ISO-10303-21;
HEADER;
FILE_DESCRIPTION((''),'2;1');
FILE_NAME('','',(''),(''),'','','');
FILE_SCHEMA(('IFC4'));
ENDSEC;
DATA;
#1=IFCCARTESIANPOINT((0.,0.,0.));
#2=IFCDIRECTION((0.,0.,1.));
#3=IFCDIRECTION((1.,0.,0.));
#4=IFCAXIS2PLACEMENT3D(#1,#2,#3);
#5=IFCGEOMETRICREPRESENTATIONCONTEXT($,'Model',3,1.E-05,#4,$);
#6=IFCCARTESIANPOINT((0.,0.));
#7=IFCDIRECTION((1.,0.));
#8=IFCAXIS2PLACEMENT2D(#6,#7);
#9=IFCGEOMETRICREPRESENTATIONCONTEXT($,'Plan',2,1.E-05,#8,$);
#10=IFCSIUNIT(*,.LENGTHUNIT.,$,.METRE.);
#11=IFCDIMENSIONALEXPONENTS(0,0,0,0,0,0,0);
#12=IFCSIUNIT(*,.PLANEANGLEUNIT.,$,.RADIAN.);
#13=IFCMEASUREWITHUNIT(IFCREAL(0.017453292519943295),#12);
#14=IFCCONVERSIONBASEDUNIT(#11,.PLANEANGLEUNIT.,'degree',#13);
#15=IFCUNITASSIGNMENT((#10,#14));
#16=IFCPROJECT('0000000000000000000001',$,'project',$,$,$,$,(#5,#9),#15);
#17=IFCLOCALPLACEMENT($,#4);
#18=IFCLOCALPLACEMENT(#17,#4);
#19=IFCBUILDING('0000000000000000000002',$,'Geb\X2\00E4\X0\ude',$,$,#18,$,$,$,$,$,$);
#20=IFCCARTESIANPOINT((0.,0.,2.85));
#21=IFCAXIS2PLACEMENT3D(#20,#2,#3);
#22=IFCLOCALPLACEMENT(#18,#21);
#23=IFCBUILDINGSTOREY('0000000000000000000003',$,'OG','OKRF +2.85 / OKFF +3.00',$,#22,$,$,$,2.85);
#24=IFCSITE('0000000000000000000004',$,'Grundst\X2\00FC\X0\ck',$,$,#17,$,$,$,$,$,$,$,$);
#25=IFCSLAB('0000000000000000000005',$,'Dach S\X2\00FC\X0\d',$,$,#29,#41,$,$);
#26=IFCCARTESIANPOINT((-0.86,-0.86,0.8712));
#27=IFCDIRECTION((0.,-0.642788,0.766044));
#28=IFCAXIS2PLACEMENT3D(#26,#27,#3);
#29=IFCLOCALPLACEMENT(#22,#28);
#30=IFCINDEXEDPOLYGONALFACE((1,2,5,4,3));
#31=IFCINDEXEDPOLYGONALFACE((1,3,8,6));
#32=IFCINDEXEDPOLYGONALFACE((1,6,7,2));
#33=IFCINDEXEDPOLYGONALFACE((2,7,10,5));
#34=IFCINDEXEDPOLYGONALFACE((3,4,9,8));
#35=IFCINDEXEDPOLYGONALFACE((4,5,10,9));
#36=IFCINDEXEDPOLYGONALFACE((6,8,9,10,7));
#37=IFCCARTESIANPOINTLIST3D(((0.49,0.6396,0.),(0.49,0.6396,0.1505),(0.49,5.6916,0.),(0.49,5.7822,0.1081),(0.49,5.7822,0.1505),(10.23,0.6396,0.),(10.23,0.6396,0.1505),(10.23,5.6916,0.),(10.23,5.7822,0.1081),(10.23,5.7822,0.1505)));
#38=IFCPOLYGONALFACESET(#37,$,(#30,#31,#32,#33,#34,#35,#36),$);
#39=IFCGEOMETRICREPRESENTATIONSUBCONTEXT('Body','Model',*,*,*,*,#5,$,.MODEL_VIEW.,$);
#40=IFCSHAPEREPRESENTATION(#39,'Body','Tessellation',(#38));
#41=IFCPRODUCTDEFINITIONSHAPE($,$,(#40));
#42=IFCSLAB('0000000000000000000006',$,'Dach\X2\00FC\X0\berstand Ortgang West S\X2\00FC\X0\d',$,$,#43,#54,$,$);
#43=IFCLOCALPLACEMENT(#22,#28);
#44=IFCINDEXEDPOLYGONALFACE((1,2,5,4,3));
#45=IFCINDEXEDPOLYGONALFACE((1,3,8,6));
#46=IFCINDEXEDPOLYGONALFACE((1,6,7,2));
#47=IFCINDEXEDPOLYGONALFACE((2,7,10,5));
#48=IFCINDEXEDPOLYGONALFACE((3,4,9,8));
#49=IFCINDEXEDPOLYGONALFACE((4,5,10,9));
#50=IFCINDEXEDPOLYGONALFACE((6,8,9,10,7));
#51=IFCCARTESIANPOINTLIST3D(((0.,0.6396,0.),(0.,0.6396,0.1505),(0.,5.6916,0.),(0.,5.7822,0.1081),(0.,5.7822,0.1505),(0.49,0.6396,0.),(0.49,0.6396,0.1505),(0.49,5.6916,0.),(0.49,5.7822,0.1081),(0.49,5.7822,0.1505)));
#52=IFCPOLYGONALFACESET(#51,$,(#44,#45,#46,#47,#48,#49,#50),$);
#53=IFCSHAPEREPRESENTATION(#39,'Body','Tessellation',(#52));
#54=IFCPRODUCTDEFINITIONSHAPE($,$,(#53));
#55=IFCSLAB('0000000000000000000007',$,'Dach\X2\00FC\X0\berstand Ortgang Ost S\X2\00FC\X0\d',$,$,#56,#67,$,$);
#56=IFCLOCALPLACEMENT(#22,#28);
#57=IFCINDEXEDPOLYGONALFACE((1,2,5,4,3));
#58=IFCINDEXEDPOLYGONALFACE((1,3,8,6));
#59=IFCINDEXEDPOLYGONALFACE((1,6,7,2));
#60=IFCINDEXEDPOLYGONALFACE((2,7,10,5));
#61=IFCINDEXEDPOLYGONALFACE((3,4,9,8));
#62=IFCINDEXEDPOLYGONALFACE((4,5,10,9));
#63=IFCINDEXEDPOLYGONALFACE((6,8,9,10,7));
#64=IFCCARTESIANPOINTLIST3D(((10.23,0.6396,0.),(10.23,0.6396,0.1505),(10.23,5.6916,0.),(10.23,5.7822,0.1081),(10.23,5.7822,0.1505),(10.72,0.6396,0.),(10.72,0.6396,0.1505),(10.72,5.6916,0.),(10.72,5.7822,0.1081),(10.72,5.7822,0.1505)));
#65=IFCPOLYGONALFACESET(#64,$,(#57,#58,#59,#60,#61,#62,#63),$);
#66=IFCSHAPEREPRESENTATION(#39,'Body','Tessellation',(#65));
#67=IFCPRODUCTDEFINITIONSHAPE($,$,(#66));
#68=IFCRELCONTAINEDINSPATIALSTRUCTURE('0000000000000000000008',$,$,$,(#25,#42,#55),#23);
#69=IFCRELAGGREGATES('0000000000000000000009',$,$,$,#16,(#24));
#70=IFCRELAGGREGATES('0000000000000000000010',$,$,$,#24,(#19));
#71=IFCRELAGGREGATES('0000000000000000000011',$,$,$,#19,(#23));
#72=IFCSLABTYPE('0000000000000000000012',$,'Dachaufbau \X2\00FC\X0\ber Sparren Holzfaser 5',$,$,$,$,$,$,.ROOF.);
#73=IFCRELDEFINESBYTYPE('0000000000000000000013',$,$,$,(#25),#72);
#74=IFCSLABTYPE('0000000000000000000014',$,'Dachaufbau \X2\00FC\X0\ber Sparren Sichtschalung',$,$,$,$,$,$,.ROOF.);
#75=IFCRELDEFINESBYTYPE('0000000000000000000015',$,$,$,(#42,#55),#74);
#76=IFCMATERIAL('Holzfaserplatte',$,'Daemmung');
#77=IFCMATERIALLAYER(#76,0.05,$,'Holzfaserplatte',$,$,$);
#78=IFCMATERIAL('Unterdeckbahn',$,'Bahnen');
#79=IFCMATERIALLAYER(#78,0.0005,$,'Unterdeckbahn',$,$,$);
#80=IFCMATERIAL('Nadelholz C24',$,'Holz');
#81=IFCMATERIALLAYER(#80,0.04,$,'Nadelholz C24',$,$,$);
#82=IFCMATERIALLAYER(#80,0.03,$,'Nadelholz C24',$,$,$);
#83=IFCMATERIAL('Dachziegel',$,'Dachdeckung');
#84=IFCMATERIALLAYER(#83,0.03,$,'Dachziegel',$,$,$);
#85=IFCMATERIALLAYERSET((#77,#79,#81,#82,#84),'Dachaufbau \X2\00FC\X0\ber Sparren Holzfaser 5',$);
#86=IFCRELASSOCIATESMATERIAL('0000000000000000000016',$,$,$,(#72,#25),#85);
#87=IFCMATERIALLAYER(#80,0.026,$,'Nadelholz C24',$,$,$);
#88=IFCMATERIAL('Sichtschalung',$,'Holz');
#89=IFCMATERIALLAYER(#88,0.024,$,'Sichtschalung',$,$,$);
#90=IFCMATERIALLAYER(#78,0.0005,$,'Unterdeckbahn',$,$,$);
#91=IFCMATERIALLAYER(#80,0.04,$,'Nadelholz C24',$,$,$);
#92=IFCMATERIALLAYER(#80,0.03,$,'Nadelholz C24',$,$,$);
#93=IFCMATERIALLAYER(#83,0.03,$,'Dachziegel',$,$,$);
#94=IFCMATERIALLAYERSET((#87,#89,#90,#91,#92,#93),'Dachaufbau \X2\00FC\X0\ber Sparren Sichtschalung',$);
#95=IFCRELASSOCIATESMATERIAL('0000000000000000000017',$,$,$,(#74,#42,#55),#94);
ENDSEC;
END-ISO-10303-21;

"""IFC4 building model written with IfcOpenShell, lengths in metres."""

from ifc_helpers import new_model, entity, si_unit, converted_unit, frame, origin_with_axes, origin_2d_with_axis, place, context, subcontext, project, spatial, indexed_curve, outline, extrude, clip, halfspace, material, layer, layer_set, layer_usage, type_object, element, save


model = new_model("IFC4")

# Units and contexts
model_context = context("Model", 3, precision=1e-05, world=origin_with_axes())
plan_context = context("Plan", 2, precision=1e-05, world=origin_2d_with_axis())
body_context_1 = subcontext(model_context, "Body", "Model", "MODEL_VIEW")
ifc_project = project(units=[si_unit("LENGTHUNIT", "METRE"), converted_unit("PLANEANGLEUNIT", "degree", entity("IfcReal", 0.017453292519943295), si_unit("PLANEANGLEUNIT", "RADIAN"), dimensions=[0, 0, 0, 0, 0, 0, 0])], contexts=[model_context, plan_context])

# Site, building, storey
site_placement = place(None, origin_with_axes())
site = spatial("IfcSite", under=ifc_project, at=site_placement, Name="Grundstück")
building_placement = place(site_placement, origin_with_axes())
building = spatial("IfcBuilding", under=site, at=building_placement, Name="Gebäude")
storey_placement = place(building_placement, frame((0.0, 0.0, 2.85), z_axis=(0.0, 0.0, 1.0), x_axis=(1.0, 0.0, 0.0)))
storey = spatial("IfcBuildingStorey", under=building, at=storey_placement, Name="OG", Description="OKRF +2.85 / OKFF +3.00", Elevation=2.85)

# Shared definitions
ifc_material_1 = material(Name="Nadelholz C24", Category="Holz")

# Slabs
ifc_material_2 = material(Name="Holzfaserplatte", Category="Daemmung")
ifc_layer_1 = layer(ifc_material_2, 0.05, Name="Holzfaserplatte")
ifc_material_3 = material(Name="Unterdeckbahn", Category="Bahnen")
ifc_layer_2 = layer(ifc_material_3, 0.0005, Name="Unterdeckbahn")
ifc_layer_3 = layer(ifc_material_1, 0.04, Name="Nadelholz C24")
ifc_layer_4 = layer(ifc_material_1, 0.03, Name="Nadelholz C24")
ifc_material_4 = material(Name="Dachziegel", Category="Dachdeckung")
ifc_layer_5 = layer(ifc_material_4, 0.03, Name="Dachziegel")
ifc_layer_set_1 = layer_set([ifc_layer_1, ifc_layer_2, ifc_layer_3, ifc_layer_4, ifc_layer_5], Name="Dachaufbau über Sparren Holzfaser 5")
ifc_layer_usage_1 = layer_usage(ifc_layer_set_1, "AXIS3", "POSITIVE", 0.0)
slab_type_1 = type_object("IfcSlabType", Name="Dachaufbau über Sparren Holzfaser 5", PredefinedType="ROOF", material=ifc_layer_set_1)
slab_1_placement = place(storey_placement, frame((-0.86, -0.86, 0.8712), z_axis=(0.0, -0.642788, 0.766044), x_axis=(1.0, 0.0, 0.0)))
element("IfcSlab", 1, at=slab_1_placement, inside=storey, type_object=slab_type_1, material=ifc_layer_usage_1, Name="Dach Süd", context=body_context_1, shape_type="Clipping", body=[
    clip(extrude(outline(indexed_curve([(0.49, 0.6396), (10.23, 0.6396), (10.23, 5.7822), (0.49, 5.7822)])), None, (0.0, 0.0, 1.0), 0.1505), halfspace(frame((0.86, 0.948, -5.6532), z_axis=(0.0, 0.766044, -0.642788), x_axis=(1.0, 0.0, 0.0)), False)),
])
ifc_layer_6 = layer(ifc_material_1, 0.026, Name="Nadelholz C24")
ifc_material_5 = material(Name="Sichtschalung", Category="Holz")
ifc_layer_7 = layer(ifc_material_5, 0.024, Name="Sichtschalung")
ifc_layer_8 = layer(ifc_material_3, 0.0005, Name="Unterdeckbahn")
ifc_layer_9 = layer(ifc_material_1, 0.04, Name="Nadelholz C24")
ifc_layer_10 = layer(ifc_material_1, 0.03, Name="Nadelholz C24")
ifc_layer_11 = layer(ifc_material_4, 0.03, Name="Dachziegel")
ifc_layer_set_2 = layer_set([ifc_layer_6, ifc_layer_7, ifc_layer_8, ifc_layer_9, ifc_layer_10, ifc_layer_11], Name="Dachaufbau über Sparren Sichtschalung")
slab_type_2 = type_object("IfcSlabType", Name="Dachaufbau über Sparren Sichtschalung", PredefinedType="ROOF", material=ifc_layer_set_2)
ifc_layer_usage_2 = layer_usage(ifc_layer_set_2, "AXIS3", "POSITIVE", 0.0)
slab_2_placement = place(storey_placement, frame((-0.86, -0.86, 0.8712), z_axis=(0.0, -0.642788, 0.766044), x_axis=(1.0, 0.0, 0.0)))
element("IfcSlab", 2, at=slab_2_placement, inside=storey, type_object=slab_type_2, material=ifc_layer_usage_2, Name="Dachüberstand Ortgang West Süd", context=body_context_1, shape_type="Clipping", body=[
    clip(extrude(outline(indexed_curve([(0.0, 0.6396), (0.49, 0.6396), (0.49, 5.7822), (0.0, 5.7822)])), None, (0.0, 0.0, 1.0), 0.1505), halfspace(frame((0.86, 0.948, -5.6532), z_axis=(0.0, 0.766044, -0.642788), x_axis=(1.0, 0.0, 0.0)), False)),
])
ifc_layer_usage_3 = layer_usage(ifc_layer_set_2, "AXIS3", "POSITIVE", 0.0)
slab_3_placement = place(storey_placement, frame((-0.86, -0.86, 0.8712), z_axis=(0.0, -0.642788, 0.766044), x_axis=(1.0, 0.0, 0.0)))
element("IfcSlab", 3, at=slab_3_placement, inside=storey, type_object=slab_type_2, material=ifc_layer_usage_3, Name="Dachüberstand Ortgang Ost Süd", context=body_context_1, shape_type="Clipping", body=[
    clip(extrude(outline(indexed_curve([(10.23, 0.6396), (10.72, 0.6396), (10.72, 5.7822), (10.23, 5.7822)])), None, (0.0, 0.0, 1.0), 0.1505), halfspace(frame((0.86, 0.948, -5.6532), z_axis=(0.0, 0.766044, -0.642788), x_axis=(1.0, 0.0, 0.0)), False)),
])

save(model, "model.ifc")
